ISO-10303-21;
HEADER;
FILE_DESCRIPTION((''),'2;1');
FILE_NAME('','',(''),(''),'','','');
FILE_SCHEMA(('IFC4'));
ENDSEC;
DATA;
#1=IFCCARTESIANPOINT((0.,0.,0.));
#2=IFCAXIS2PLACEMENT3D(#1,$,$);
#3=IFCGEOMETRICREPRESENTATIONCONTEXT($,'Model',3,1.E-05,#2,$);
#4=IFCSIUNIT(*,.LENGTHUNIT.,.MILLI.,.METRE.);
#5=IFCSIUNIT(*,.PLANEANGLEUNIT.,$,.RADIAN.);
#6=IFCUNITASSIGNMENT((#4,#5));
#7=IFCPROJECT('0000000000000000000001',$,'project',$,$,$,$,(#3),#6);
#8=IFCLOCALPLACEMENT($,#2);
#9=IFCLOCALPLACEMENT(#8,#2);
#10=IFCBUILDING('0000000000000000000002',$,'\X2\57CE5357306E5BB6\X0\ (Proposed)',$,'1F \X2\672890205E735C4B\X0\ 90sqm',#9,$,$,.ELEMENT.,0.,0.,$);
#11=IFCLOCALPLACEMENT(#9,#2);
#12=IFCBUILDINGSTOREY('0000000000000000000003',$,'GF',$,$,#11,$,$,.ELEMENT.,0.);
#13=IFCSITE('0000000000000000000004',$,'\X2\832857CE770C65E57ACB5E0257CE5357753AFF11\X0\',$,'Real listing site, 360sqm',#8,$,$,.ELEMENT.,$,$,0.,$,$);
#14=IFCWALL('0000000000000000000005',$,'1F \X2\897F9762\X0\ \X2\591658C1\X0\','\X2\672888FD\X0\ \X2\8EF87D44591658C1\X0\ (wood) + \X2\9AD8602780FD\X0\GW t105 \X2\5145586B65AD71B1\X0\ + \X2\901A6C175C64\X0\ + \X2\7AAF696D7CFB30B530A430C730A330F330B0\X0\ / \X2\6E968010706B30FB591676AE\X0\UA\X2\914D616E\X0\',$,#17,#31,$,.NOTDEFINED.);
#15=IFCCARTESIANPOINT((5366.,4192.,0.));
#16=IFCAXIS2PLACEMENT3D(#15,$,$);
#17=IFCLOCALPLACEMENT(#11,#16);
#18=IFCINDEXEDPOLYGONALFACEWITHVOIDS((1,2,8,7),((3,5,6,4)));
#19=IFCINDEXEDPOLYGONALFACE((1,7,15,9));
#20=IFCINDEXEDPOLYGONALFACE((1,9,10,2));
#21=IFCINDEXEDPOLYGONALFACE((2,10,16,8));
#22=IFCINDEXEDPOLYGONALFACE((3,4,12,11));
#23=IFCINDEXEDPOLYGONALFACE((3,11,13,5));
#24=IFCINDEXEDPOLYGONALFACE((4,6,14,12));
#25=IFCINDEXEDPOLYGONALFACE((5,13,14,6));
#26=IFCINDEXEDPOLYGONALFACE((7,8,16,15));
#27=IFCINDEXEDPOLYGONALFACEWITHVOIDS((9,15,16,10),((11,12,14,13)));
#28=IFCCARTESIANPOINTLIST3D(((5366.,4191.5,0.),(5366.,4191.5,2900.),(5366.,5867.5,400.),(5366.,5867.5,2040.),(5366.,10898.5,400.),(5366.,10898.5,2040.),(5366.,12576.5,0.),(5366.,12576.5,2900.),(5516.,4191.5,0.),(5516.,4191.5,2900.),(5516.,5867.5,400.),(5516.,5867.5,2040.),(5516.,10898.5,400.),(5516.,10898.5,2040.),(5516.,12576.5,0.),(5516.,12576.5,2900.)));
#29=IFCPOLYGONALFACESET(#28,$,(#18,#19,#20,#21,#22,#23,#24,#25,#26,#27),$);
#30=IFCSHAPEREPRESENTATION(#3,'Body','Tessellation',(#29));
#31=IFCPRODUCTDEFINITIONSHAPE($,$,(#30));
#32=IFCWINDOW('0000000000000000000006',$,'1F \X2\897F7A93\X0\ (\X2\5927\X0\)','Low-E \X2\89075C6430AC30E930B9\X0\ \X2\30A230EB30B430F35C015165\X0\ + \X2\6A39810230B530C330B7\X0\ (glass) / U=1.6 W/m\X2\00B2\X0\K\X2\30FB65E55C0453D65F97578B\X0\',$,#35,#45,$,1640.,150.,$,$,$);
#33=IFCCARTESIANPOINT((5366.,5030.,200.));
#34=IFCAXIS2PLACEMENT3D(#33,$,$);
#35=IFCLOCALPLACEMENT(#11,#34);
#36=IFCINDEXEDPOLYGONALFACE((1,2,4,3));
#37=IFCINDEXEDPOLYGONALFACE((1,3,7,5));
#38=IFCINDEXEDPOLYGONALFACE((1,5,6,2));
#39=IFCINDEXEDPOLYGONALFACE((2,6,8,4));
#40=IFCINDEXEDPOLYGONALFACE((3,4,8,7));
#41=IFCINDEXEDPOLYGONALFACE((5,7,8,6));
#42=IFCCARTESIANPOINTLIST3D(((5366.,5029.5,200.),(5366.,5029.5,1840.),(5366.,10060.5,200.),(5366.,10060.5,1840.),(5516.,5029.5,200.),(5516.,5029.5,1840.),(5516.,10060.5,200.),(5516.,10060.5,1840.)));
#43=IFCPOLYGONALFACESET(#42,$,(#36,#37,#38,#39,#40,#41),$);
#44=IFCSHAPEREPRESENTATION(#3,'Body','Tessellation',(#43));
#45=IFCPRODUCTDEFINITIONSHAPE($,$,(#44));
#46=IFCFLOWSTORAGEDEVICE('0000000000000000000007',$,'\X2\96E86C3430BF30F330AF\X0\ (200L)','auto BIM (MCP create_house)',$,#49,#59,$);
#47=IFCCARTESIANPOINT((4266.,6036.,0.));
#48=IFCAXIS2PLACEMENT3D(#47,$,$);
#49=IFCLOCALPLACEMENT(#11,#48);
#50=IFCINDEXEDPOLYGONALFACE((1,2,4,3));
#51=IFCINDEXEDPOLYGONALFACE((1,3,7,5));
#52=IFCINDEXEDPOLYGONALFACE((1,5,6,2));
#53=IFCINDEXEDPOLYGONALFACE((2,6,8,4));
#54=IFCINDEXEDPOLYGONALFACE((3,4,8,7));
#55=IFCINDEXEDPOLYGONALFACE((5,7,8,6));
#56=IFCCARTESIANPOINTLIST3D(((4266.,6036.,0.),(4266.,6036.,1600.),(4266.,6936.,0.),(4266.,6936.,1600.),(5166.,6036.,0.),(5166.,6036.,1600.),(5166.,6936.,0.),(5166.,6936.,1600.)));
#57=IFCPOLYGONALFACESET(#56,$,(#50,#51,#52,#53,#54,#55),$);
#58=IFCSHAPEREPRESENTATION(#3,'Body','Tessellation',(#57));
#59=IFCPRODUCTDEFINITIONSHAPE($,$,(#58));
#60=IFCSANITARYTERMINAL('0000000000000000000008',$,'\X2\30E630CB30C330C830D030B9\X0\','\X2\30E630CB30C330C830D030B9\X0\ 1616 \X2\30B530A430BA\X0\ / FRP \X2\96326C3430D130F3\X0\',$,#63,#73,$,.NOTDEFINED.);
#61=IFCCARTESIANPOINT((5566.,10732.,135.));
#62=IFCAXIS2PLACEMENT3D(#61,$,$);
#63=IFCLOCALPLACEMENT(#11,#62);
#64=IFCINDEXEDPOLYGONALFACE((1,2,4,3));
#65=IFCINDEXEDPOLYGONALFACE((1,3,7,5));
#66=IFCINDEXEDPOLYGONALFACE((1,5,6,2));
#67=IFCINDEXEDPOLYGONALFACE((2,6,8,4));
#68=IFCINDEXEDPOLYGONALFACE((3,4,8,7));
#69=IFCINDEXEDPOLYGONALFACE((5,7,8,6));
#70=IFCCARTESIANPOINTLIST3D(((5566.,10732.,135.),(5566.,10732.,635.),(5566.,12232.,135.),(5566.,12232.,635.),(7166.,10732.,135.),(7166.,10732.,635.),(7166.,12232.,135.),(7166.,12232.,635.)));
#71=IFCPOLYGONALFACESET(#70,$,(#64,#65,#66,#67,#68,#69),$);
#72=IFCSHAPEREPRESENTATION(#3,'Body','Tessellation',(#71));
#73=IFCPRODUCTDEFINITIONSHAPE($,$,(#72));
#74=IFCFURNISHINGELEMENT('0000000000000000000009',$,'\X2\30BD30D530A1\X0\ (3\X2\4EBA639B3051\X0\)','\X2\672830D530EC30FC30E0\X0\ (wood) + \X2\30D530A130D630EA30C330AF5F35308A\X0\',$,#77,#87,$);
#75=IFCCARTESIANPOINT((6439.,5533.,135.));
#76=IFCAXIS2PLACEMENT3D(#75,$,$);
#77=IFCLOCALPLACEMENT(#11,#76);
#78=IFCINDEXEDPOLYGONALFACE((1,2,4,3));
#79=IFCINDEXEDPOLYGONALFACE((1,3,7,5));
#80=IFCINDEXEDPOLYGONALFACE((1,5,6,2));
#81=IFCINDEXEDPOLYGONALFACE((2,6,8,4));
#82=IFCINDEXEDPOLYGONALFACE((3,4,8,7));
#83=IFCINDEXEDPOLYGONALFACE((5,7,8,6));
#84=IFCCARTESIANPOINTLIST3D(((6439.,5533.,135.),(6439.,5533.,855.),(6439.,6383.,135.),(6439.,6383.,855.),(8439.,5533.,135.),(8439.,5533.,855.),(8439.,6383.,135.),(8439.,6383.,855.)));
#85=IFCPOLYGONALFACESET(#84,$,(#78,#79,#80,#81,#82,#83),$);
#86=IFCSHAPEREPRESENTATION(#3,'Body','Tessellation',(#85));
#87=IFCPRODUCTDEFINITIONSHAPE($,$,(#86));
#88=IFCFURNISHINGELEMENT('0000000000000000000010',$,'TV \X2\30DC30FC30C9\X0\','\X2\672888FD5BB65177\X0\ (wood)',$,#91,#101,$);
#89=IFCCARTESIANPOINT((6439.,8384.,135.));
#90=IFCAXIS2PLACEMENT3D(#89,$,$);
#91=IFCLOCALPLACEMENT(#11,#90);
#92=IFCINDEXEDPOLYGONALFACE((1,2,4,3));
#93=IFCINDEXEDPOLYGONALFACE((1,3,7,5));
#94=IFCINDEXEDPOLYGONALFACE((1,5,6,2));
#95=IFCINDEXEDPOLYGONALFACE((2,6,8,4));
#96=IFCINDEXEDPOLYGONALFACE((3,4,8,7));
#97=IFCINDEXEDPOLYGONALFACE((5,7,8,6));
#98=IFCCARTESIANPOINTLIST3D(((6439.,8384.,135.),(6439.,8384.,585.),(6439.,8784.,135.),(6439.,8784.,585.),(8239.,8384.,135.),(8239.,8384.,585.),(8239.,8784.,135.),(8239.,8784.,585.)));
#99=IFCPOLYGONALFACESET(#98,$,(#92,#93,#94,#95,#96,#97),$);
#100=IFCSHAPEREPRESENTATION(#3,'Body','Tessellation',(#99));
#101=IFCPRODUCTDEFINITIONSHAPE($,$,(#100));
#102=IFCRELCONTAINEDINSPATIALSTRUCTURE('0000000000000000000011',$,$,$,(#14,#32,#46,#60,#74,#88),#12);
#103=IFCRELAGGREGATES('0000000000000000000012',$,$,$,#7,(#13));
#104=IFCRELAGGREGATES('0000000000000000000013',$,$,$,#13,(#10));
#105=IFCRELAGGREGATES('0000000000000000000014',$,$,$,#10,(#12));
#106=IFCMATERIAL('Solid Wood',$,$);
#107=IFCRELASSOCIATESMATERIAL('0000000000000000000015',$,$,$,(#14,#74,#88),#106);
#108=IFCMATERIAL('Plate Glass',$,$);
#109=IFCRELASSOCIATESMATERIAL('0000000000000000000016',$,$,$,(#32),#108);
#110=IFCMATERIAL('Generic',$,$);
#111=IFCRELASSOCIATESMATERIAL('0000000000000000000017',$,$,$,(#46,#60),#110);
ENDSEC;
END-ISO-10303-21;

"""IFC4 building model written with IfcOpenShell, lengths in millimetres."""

from ifc_helpers import new_model, si_unit, frame, frame_2d, origin, place, context, project, spatial, rectangle, extrude, material, element, fill, save


model = new_model("IFC4")

# Units and contexts
model_context = context("Model", 3, precision=1e-05, world=origin())
ifc_project = project(units=[si_unit("LENGTHUNIT", "METRE", prefix="MILLI"), si_unit("PLANEANGLEUNIT", "RADIAN")], contexts=[model_context])

# Site, building, storey
site_placement = place(None, origin())
site = spatial("IfcSite", under=ifc_project, at=site_placement, Name="茨城県日立市城南町１", ObjectType="Real listing site, 360sqm", CompositionType="ELEMENT", RefElevation=0.0)
building_placement = place(site_placement, origin())
building = spatial("IfcBuilding", under=site, at=building_placement, Name="城南の家 (Proposed)", ObjectType="1F 木造平屋 90sqm", CompositionType="ELEMENT", ElevationOfRefHeight=0.0, ElevationOfTerrain=0.0)
storey_placement = place(building_placement, origin())
storey = spatial("IfcBuildingStorey", under=building, at=storey_placement, Name="GF", CompositionType="ELEMENT", Elevation=0.0)

# Shared definitions
ifc_material_1 = material(Name="Solid Wood")

# Shared definitions
ifc_material_2 = material(Name="Plate Glass")

# Wall, opening, window
wall_1_placement = place(storey_placement, frame((5366.0, 4192.0, 0.0)))
wall_1 = element("IfcWall", 1, at=wall_1_placement, inside=storey, material=ifc_material_1, Name="1F 西面 外壁", Description="木製 軸組外壁 (wood) + 高性能GW t105 充填断熱 + 通気層 + 窯業系サイディング / 準耐火・外皮UA配慮", PredefinedType="NOTDEFINED", context=model_context, shape_type="SweptSolid", body=[
    extrude(rectangle(XDim=150.0, YDim=8385.0, at=frame_2d((75.0, 4192.0))), frame((5366.0, 4192.0, 0.0)), (0.0, 0.0, 1.0), 2900.0),
])
opening_1_placement = place(storey_placement, frame((5366.0, 5030.0, 200.0)))
opening_1 = element("IfcOpeningElement", 2, at=opening_1_placement, cuts=wall_1, PredefinedType="NOTDEFINED", context=model_context, shape_type="SweptSolid", body=[
    extrude(rectangle(XDim=150.0, YDim=5031.0, at=frame_2d((75.0, 2515.0))), frame((5366.0, 5030.0, 200.0)), (0.0, 0.0, 1.0), 1640.0),
])
window_1_placement = place(storey_placement, frame((5366.0, 5030.0, 200.0)))
window_1 = element("IfcWindow", 3, at=window_1_placement, inside=storey, material=ifc_material_2, Name="1F 西窓 (大)", Description="Low-E 複層ガラス アルゴン封入 + 樹脂サッシ (glass) / U=1.6 W/m²K・日射取得型", OverallHeight=1640.0, OverallWidth=150.0, context=model_context, shape_type="SweptSolid", body=[
    extrude(rectangle(XDim=150.0, YDim=5031.0, at=frame_2d((75.0, 2515.0))), frame((5366.0, 5030.0, 200.0)), (0.0, 0.0, 1.0), 1640.0),
])
fill(opening_1, window_1)

# Shared definitions
ifc_material_3 = material(Name="Generic")

# Flow storage device
flow_storage_device_placement = place(storey_placement, frame((4266.0, 6036.0, 0.0)))
element("IfcFlowStorageDevice", 4, at=flow_storage_device_placement, inside=storey, material=ifc_material_3, Name="雨水タンク (200L)", Description="auto BIM (MCP create_house)", context=model_context, shape_type="SweptSolid", body=[
    extrude(rectangle(XDim=900.0, YDim=900.0, at=frame_2d((450.0, 450.0))), frame((4266.0, 6036.0, 0.0)), (0.0, 0.0, 1.0), 1600.0),
])

# Sanitary terminal
sanitary_terminal_placement = place(storey_placement, frame((5566.0, 10732.0, 135.0)))
element("IfcSanitaryTerminal", 5, at=sanitary_terminal_placement, inside=storey, material=ifc_material_3, Name="ユニットバス", Description="ユニットバス 1616 サイズ / FRP 防水パン", PredefinedType="NOTDEFINED", context=model_context, shape_type="SweptSolid", body=[
    extrude(rectangle(XDim=1600.0, YDim=1500.0, at=frame_2d((800.0, 750.0))), frame((5566.0, 10732.0, 135.0)), (0.0, 0.0, 1.0), 500.0),
])

# Furnishing elements
furnishing_1_placement = place(storey_placement, frame((6439.0, 5533.0, 135.0)))
element("IfcFurnishingElement", 6, at=furnishing_1_placement, inside=storey, material=ifc_material_1, Name="ソファ (3人掛け)", Description="木フレーム (wood) + ファブリック張り", context=model_context, shape_type="SweptSolid", body=[
    extrude(rectangle(XDim=2000.0, YDim=850.0, at=frame_2d((1000.0, 425.0))), frame((6439.0, 5533.0, 135.0)), (0.0, 0.0, 1.0), 720.0),
])
furnishing_2_placement = place(storey_placement, frame((6439.0, 8384.0, 135.0)))
element("IfcFurnishingElement", 7, at=furnishing_2_placement, inside=storey, material=ifc_material_1, Name="TV ボード", Description="木製家具 (wood)", context=model_context, shape_type="SweptSolid", body=[
    extrude(rectangle(XDim=1800.0, YDim=400.0, at=frame_2d((900.0, 200.0))), frame((6439.0, 8384.0, 135.0)), (0.0, 0.0, 1.0), 450.0),
])

save(model, "model.ifc")
